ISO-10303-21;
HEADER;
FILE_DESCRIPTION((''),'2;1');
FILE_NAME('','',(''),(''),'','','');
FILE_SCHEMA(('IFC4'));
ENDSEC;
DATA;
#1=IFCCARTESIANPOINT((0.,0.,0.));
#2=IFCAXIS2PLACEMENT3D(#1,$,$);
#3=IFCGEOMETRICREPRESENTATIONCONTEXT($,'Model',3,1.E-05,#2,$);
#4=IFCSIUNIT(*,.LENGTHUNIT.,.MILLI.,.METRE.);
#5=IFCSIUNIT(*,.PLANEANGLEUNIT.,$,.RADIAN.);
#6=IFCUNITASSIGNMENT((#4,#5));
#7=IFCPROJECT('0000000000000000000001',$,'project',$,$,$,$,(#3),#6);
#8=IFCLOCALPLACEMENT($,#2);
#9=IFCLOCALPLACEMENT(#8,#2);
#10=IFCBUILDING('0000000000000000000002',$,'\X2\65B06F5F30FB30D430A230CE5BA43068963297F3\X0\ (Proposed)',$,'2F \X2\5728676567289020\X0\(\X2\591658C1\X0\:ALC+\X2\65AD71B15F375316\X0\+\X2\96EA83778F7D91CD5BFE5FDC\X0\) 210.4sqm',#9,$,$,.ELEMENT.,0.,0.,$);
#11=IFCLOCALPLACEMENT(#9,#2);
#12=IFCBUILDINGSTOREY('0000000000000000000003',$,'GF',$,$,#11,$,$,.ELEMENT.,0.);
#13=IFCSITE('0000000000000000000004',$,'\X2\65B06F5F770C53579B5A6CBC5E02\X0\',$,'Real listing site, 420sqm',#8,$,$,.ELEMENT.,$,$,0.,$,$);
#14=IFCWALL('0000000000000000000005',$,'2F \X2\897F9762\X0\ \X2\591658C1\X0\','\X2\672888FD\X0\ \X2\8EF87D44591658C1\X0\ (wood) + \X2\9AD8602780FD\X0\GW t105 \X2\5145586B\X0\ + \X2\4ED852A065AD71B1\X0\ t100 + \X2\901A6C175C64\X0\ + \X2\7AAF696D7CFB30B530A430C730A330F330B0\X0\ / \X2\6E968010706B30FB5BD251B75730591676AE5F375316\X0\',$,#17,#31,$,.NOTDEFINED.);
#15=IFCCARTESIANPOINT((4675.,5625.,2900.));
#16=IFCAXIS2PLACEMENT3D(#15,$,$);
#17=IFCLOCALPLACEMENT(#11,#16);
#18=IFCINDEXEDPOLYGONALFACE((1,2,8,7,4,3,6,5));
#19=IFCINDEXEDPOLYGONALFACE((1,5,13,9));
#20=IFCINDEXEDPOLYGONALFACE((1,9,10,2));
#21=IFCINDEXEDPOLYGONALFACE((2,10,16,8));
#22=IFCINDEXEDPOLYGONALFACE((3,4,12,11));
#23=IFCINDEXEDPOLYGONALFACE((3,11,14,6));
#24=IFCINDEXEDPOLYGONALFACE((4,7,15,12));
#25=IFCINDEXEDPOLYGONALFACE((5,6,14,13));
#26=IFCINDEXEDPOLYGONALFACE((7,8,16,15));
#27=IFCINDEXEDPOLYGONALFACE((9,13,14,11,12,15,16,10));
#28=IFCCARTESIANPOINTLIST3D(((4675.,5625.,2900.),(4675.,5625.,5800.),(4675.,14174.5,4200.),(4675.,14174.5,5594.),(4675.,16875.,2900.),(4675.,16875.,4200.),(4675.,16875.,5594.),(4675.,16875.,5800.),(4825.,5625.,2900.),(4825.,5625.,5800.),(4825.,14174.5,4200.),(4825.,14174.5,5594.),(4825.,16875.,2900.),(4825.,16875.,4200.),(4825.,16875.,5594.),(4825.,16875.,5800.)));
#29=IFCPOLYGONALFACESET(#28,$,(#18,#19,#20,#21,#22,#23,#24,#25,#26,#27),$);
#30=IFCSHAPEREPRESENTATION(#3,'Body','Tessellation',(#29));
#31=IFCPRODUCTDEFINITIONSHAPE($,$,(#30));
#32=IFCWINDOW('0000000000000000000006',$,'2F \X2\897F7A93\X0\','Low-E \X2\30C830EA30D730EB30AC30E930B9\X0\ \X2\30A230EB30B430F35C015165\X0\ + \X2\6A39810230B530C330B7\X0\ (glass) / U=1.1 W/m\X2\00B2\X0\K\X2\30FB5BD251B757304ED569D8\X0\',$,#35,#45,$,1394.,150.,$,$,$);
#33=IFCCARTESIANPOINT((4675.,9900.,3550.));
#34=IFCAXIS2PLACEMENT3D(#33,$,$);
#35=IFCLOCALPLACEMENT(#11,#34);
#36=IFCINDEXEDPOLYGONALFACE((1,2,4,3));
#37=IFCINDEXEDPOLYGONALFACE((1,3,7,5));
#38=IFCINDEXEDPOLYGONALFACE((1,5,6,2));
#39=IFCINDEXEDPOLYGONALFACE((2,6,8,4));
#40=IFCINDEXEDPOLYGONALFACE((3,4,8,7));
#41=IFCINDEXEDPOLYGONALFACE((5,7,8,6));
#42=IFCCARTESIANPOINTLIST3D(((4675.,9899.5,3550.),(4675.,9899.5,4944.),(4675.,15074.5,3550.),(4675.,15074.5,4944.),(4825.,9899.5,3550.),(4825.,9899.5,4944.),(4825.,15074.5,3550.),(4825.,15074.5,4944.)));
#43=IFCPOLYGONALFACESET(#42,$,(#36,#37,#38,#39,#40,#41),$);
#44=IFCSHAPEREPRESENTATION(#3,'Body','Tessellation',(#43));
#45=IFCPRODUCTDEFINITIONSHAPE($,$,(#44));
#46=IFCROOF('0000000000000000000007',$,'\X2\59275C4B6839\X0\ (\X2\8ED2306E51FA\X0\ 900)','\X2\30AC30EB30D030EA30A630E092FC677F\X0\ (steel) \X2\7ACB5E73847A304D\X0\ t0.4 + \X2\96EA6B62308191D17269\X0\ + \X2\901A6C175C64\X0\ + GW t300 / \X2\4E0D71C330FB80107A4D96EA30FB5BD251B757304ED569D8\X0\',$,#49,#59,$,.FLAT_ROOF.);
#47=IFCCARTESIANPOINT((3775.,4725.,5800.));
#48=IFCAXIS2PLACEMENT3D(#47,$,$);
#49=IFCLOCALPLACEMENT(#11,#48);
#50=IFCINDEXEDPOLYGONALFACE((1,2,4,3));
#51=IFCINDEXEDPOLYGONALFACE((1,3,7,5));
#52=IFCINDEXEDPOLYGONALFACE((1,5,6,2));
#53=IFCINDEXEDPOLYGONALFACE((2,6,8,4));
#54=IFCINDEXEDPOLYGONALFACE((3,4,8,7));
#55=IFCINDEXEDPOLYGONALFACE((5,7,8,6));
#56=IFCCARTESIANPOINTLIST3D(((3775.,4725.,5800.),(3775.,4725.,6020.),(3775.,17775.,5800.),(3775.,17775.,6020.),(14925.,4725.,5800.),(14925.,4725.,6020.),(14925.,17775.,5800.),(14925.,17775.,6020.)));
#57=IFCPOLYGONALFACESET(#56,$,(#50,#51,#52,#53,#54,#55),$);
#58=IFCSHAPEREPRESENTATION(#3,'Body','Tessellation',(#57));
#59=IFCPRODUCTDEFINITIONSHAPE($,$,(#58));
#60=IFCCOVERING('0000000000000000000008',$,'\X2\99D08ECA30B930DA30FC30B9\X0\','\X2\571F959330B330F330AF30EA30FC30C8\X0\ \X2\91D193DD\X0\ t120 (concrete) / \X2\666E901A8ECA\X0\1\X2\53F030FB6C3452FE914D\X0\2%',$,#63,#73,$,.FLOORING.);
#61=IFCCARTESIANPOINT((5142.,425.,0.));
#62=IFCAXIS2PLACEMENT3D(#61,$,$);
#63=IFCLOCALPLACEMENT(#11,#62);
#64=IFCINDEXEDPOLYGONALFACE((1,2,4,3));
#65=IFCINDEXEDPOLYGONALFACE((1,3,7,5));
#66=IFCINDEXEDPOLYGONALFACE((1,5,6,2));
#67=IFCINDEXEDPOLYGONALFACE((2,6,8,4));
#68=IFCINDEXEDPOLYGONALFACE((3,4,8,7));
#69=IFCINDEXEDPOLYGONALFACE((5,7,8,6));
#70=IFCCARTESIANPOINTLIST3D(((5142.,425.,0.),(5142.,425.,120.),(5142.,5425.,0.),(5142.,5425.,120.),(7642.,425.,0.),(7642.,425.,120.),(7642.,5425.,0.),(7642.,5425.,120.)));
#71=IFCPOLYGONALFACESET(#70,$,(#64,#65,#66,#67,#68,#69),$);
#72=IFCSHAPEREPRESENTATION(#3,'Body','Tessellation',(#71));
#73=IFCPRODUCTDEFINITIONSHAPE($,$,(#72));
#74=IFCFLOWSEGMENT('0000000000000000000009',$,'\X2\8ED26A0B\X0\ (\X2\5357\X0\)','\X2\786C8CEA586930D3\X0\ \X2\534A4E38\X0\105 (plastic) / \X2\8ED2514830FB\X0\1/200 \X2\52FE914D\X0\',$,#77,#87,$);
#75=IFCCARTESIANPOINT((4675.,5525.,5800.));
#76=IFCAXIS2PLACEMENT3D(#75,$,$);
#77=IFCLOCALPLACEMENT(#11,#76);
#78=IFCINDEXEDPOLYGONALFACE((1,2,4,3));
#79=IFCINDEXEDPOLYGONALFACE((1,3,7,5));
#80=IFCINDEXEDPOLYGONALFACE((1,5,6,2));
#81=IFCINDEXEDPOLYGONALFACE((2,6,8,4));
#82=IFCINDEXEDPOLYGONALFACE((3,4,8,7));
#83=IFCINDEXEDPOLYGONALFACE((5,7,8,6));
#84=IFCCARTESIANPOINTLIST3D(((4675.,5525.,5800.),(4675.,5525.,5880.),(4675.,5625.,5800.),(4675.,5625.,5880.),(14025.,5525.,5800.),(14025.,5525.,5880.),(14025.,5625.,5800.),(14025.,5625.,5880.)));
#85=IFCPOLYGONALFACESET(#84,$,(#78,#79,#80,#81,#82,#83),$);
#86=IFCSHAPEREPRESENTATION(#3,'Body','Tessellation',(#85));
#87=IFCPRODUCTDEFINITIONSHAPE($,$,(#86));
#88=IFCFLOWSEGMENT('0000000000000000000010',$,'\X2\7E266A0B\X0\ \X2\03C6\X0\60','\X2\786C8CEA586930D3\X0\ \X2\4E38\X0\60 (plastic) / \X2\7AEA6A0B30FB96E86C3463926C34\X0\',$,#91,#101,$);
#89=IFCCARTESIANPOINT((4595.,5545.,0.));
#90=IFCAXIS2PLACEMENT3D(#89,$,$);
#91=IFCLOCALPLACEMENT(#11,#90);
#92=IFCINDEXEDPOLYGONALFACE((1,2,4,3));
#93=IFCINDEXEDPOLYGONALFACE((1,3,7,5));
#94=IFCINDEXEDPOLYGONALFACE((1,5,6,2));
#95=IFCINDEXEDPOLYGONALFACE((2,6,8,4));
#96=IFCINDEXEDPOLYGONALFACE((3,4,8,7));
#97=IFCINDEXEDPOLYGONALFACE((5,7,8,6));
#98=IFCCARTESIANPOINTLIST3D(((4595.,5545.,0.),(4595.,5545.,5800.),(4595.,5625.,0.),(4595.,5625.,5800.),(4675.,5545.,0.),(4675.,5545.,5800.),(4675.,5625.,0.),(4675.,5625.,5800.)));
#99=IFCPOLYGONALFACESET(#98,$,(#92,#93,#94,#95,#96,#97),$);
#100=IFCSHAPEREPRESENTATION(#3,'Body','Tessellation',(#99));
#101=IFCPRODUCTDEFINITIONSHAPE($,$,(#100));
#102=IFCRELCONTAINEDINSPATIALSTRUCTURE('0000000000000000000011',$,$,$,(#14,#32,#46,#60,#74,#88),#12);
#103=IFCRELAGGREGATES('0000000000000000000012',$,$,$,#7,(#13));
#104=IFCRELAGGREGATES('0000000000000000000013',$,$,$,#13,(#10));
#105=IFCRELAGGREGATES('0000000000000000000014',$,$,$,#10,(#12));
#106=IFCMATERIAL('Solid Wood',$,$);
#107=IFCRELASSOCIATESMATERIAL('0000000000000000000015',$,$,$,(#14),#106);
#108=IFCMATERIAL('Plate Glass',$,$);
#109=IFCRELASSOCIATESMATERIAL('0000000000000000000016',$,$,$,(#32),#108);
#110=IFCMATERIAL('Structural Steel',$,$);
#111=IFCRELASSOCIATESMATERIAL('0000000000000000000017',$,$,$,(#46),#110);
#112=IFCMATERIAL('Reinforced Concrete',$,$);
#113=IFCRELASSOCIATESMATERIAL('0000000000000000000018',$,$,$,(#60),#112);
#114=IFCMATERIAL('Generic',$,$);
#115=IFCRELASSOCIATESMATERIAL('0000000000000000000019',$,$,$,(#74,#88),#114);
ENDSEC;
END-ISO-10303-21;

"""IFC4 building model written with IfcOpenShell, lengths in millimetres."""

from ifc_helpers import new_model, si_unit, frame, frame_2d, origin, place, context, project, spatial, rectangle, extrude, material, element, fill, save


model = new_model("IFC4")

# Units and contexts
model_context = context("Model", 3, precision=1e-05, world=origin())
ifc_project = project(units=[si_unit("LENGTHUNIT", "METRE", prefix="MILLI"), si_unit("PLANEANGLEUNIT", "RADIAN")], contexts=[model_context])

# Site, building, storey
site_placement = place(None, origin())
site = spatial("IfcSite", under=ifc_project, at=site_placement, Name="新潟県南魚沼市", ObjectType="Real listing site, 420sqm", CompositionType="ELEMENT", RefElevation=0.0)
building_placement = place(site_placement, origin())
building = spatial("IfcBuilding", under=site, at=building_placement, Name="新潟・ピアノ室と防音 (Proposed)", ObjectType="2F 在来木造(外壁:ALC+断熱強化+雪荷载重対応) 210.4sqm", CompositionType="ELEMENT", ElevationOfRefHeight=0.0, ElevationOfTerrain=0.0)
storey_placement = place(building_placement, origin())
storey = spatial("IfcBuildingStorey", under=building, at=storey_placement, Name="GF", CompositionType="ELEMENT", Elevation=0.0)

# Shared definitions
ifc_material_1 = material(Name="Solid Wood")

# Shared definitions
ifc_material_2 = material(Name="Reinforced Concrete")

# Shared definitions
ifc_material_3 = material(Name="Plate Glass")

# Wall, opening, window
wall_1_placement = place(storey_placement, frame((4675.0, 5625.0, 2900.0)))
wall_1 = element("IfcWall", 1, at=wall_1_placement, inside=storey, material=ifc_material_1, Name="2F 西面 外壁", Description="木製 軸組外壁 (wood) + 高性能GW t105 充填 + 付加断熱 t100 + 通気層 + 窯業系サイディング / 準耐火・寒冷地外皮強化", PredefinedType="NOTDEFINED", context=model_context, shape_type="SweptSolid", body=[
    extrude(rectangle(XDim=150.0, YDim=11250.0, at=frame_2d((75.0, 5625.0))), frame((4675.0, 5625.0, 2900.0)), (0.0, 0.0, 1.0), 2900.0),
])
opening_1_placement = place(storey_placement, frame((4675.0, 9900.0, 3550.0)))
opening_1 = element("IfcOpeningElement", 2, at=opening_1_placement, cuts=wall_1, PredefinedType="NOTDEFINED", context=model_context, shape_type="SweptSolid", body=[
    extrude(rectangle(XDim=150.0, YDim=5175.0, at=frame_2d((75.0, 2587.0))), frame((4675.0, 9900.0, 3550.0)), (0.0, 0.0, 1.0), 1394.0),
])
window_1_placement = place(storey_placement, frame((4675.0, 9900.0, 3550.0)))
window_1 = element("IfcWindow", 3, at=window_1_placement, inside=storey, material=ifc_material_3, Name="2F 西窓", Description="Low-E トリプルガラス アルゴン封入 + 樹脂サッシ (glass) / U=1.1 W/m²K・寒冷地仕様", OverallHeight=1394.0, OverallWidth=150.0, context=model_context, shape_type="SweptSolid", body=[
    extrude(rectangle(XDim=150.0, YDim=5175.0, at=frame_2d((75.0, 2587.0))), frame((4675.0, 9900.0, 3550.0)), (0.0, 0.0, 1.0), 1394.0),
])
fill(opening_1, window_1)

# Roof
ifc_material_4 = material(Name="Structural Steel")
roof_placement = place(storey_placement, frame((3775.0, 4725.0, 5800.0)))
element("IfcRoof", 4, at=roof_placement, inside=storey, material=ifc_material_4, Name="大屋根 (軒の出 900)", Description="ガルバリウム鋼板 (steel) 立平葺き t0.4 + 雪止め金物 + 通気層 + GW t300 / 不燃・耐積雪・寒冷地仕様", PredefinedType="FLAT_ROOF", context=model_context, shape_type="SweptSolid", body=[
    extrude(rectangle(XDim=11150.0, YDim=13050.0, at=frame_2d((5575.0, 6525.0))), frame((3775.0, 4725.0, 5800.0)), (0.0, 0.0, 1.0), 220.0),
])

# Covering
covering_placement = place(storey_placement, frame((5142.0, 425.0, 0.0)))
element("IfcCovering", 5, at=covering_placement, inside=storey, material=ifc_material_2, Name="駐車スペース", Description="土間コンクリート 金鏝 t120 (concrete) / 普通車1台・水勾配2%", PredefinedType="FLOORING", context=model_context, shape_type="SweptSolid", body=[
    extrude(rectangle(XDim=2500.0, YDim=5000.0, at=frame_2d((1250.0, 2500.0))), frame((5142.0, 425.0, 0.0)), (0.0, 0.0, 1.0), 120.0),
])

# Flow segments
ifc_material_5 = material(Name="Generic")
flow_segment_1_placement = place(storey_placement, frame((4675.0, 5525.0, 5800.0)))
element("IfcFlowSegment", 6, at=flow_segment_1_placement, inside=storey, material=ifc_material_5, Name="軒樋 (南)", Description="硬質塩ビ 半丸105 (plastic) / 軒先・1/200 勾配", context=model_context, shape_type="SweptSolid", body=[
    extrude(rectangle(XDim=9350.0, YDim=100.0, at=frame_2d((4675.0, 50.0))), frame((4675.0, 5525.0, 5800.0)), (0.0, 0.0, 1.0), 80.0),
])
flow_segment_2_placement = place(storey_placement, frame((4595.0, 5545.0, 0.0)))
element("IfcFlowSegment", 7, at=flow_segment_2_placement, inside=storey, material=ifc_material_5, Name="縦樋 φ60", Description="硬質塩ビ 丸60 (plastic) / 竪樋・雨水排水", context=model_context, shape_type="SweptSolid", body=[
    extrude(rectangle(XDim=80.0, YDim=80.0, at=frame_2d((40.0, 40.0))), frame((4595.0, 5545.0, 0.0)), (0.0, 0.0, 1.0), 5800.0),
])

save(model, "model.ifc")
